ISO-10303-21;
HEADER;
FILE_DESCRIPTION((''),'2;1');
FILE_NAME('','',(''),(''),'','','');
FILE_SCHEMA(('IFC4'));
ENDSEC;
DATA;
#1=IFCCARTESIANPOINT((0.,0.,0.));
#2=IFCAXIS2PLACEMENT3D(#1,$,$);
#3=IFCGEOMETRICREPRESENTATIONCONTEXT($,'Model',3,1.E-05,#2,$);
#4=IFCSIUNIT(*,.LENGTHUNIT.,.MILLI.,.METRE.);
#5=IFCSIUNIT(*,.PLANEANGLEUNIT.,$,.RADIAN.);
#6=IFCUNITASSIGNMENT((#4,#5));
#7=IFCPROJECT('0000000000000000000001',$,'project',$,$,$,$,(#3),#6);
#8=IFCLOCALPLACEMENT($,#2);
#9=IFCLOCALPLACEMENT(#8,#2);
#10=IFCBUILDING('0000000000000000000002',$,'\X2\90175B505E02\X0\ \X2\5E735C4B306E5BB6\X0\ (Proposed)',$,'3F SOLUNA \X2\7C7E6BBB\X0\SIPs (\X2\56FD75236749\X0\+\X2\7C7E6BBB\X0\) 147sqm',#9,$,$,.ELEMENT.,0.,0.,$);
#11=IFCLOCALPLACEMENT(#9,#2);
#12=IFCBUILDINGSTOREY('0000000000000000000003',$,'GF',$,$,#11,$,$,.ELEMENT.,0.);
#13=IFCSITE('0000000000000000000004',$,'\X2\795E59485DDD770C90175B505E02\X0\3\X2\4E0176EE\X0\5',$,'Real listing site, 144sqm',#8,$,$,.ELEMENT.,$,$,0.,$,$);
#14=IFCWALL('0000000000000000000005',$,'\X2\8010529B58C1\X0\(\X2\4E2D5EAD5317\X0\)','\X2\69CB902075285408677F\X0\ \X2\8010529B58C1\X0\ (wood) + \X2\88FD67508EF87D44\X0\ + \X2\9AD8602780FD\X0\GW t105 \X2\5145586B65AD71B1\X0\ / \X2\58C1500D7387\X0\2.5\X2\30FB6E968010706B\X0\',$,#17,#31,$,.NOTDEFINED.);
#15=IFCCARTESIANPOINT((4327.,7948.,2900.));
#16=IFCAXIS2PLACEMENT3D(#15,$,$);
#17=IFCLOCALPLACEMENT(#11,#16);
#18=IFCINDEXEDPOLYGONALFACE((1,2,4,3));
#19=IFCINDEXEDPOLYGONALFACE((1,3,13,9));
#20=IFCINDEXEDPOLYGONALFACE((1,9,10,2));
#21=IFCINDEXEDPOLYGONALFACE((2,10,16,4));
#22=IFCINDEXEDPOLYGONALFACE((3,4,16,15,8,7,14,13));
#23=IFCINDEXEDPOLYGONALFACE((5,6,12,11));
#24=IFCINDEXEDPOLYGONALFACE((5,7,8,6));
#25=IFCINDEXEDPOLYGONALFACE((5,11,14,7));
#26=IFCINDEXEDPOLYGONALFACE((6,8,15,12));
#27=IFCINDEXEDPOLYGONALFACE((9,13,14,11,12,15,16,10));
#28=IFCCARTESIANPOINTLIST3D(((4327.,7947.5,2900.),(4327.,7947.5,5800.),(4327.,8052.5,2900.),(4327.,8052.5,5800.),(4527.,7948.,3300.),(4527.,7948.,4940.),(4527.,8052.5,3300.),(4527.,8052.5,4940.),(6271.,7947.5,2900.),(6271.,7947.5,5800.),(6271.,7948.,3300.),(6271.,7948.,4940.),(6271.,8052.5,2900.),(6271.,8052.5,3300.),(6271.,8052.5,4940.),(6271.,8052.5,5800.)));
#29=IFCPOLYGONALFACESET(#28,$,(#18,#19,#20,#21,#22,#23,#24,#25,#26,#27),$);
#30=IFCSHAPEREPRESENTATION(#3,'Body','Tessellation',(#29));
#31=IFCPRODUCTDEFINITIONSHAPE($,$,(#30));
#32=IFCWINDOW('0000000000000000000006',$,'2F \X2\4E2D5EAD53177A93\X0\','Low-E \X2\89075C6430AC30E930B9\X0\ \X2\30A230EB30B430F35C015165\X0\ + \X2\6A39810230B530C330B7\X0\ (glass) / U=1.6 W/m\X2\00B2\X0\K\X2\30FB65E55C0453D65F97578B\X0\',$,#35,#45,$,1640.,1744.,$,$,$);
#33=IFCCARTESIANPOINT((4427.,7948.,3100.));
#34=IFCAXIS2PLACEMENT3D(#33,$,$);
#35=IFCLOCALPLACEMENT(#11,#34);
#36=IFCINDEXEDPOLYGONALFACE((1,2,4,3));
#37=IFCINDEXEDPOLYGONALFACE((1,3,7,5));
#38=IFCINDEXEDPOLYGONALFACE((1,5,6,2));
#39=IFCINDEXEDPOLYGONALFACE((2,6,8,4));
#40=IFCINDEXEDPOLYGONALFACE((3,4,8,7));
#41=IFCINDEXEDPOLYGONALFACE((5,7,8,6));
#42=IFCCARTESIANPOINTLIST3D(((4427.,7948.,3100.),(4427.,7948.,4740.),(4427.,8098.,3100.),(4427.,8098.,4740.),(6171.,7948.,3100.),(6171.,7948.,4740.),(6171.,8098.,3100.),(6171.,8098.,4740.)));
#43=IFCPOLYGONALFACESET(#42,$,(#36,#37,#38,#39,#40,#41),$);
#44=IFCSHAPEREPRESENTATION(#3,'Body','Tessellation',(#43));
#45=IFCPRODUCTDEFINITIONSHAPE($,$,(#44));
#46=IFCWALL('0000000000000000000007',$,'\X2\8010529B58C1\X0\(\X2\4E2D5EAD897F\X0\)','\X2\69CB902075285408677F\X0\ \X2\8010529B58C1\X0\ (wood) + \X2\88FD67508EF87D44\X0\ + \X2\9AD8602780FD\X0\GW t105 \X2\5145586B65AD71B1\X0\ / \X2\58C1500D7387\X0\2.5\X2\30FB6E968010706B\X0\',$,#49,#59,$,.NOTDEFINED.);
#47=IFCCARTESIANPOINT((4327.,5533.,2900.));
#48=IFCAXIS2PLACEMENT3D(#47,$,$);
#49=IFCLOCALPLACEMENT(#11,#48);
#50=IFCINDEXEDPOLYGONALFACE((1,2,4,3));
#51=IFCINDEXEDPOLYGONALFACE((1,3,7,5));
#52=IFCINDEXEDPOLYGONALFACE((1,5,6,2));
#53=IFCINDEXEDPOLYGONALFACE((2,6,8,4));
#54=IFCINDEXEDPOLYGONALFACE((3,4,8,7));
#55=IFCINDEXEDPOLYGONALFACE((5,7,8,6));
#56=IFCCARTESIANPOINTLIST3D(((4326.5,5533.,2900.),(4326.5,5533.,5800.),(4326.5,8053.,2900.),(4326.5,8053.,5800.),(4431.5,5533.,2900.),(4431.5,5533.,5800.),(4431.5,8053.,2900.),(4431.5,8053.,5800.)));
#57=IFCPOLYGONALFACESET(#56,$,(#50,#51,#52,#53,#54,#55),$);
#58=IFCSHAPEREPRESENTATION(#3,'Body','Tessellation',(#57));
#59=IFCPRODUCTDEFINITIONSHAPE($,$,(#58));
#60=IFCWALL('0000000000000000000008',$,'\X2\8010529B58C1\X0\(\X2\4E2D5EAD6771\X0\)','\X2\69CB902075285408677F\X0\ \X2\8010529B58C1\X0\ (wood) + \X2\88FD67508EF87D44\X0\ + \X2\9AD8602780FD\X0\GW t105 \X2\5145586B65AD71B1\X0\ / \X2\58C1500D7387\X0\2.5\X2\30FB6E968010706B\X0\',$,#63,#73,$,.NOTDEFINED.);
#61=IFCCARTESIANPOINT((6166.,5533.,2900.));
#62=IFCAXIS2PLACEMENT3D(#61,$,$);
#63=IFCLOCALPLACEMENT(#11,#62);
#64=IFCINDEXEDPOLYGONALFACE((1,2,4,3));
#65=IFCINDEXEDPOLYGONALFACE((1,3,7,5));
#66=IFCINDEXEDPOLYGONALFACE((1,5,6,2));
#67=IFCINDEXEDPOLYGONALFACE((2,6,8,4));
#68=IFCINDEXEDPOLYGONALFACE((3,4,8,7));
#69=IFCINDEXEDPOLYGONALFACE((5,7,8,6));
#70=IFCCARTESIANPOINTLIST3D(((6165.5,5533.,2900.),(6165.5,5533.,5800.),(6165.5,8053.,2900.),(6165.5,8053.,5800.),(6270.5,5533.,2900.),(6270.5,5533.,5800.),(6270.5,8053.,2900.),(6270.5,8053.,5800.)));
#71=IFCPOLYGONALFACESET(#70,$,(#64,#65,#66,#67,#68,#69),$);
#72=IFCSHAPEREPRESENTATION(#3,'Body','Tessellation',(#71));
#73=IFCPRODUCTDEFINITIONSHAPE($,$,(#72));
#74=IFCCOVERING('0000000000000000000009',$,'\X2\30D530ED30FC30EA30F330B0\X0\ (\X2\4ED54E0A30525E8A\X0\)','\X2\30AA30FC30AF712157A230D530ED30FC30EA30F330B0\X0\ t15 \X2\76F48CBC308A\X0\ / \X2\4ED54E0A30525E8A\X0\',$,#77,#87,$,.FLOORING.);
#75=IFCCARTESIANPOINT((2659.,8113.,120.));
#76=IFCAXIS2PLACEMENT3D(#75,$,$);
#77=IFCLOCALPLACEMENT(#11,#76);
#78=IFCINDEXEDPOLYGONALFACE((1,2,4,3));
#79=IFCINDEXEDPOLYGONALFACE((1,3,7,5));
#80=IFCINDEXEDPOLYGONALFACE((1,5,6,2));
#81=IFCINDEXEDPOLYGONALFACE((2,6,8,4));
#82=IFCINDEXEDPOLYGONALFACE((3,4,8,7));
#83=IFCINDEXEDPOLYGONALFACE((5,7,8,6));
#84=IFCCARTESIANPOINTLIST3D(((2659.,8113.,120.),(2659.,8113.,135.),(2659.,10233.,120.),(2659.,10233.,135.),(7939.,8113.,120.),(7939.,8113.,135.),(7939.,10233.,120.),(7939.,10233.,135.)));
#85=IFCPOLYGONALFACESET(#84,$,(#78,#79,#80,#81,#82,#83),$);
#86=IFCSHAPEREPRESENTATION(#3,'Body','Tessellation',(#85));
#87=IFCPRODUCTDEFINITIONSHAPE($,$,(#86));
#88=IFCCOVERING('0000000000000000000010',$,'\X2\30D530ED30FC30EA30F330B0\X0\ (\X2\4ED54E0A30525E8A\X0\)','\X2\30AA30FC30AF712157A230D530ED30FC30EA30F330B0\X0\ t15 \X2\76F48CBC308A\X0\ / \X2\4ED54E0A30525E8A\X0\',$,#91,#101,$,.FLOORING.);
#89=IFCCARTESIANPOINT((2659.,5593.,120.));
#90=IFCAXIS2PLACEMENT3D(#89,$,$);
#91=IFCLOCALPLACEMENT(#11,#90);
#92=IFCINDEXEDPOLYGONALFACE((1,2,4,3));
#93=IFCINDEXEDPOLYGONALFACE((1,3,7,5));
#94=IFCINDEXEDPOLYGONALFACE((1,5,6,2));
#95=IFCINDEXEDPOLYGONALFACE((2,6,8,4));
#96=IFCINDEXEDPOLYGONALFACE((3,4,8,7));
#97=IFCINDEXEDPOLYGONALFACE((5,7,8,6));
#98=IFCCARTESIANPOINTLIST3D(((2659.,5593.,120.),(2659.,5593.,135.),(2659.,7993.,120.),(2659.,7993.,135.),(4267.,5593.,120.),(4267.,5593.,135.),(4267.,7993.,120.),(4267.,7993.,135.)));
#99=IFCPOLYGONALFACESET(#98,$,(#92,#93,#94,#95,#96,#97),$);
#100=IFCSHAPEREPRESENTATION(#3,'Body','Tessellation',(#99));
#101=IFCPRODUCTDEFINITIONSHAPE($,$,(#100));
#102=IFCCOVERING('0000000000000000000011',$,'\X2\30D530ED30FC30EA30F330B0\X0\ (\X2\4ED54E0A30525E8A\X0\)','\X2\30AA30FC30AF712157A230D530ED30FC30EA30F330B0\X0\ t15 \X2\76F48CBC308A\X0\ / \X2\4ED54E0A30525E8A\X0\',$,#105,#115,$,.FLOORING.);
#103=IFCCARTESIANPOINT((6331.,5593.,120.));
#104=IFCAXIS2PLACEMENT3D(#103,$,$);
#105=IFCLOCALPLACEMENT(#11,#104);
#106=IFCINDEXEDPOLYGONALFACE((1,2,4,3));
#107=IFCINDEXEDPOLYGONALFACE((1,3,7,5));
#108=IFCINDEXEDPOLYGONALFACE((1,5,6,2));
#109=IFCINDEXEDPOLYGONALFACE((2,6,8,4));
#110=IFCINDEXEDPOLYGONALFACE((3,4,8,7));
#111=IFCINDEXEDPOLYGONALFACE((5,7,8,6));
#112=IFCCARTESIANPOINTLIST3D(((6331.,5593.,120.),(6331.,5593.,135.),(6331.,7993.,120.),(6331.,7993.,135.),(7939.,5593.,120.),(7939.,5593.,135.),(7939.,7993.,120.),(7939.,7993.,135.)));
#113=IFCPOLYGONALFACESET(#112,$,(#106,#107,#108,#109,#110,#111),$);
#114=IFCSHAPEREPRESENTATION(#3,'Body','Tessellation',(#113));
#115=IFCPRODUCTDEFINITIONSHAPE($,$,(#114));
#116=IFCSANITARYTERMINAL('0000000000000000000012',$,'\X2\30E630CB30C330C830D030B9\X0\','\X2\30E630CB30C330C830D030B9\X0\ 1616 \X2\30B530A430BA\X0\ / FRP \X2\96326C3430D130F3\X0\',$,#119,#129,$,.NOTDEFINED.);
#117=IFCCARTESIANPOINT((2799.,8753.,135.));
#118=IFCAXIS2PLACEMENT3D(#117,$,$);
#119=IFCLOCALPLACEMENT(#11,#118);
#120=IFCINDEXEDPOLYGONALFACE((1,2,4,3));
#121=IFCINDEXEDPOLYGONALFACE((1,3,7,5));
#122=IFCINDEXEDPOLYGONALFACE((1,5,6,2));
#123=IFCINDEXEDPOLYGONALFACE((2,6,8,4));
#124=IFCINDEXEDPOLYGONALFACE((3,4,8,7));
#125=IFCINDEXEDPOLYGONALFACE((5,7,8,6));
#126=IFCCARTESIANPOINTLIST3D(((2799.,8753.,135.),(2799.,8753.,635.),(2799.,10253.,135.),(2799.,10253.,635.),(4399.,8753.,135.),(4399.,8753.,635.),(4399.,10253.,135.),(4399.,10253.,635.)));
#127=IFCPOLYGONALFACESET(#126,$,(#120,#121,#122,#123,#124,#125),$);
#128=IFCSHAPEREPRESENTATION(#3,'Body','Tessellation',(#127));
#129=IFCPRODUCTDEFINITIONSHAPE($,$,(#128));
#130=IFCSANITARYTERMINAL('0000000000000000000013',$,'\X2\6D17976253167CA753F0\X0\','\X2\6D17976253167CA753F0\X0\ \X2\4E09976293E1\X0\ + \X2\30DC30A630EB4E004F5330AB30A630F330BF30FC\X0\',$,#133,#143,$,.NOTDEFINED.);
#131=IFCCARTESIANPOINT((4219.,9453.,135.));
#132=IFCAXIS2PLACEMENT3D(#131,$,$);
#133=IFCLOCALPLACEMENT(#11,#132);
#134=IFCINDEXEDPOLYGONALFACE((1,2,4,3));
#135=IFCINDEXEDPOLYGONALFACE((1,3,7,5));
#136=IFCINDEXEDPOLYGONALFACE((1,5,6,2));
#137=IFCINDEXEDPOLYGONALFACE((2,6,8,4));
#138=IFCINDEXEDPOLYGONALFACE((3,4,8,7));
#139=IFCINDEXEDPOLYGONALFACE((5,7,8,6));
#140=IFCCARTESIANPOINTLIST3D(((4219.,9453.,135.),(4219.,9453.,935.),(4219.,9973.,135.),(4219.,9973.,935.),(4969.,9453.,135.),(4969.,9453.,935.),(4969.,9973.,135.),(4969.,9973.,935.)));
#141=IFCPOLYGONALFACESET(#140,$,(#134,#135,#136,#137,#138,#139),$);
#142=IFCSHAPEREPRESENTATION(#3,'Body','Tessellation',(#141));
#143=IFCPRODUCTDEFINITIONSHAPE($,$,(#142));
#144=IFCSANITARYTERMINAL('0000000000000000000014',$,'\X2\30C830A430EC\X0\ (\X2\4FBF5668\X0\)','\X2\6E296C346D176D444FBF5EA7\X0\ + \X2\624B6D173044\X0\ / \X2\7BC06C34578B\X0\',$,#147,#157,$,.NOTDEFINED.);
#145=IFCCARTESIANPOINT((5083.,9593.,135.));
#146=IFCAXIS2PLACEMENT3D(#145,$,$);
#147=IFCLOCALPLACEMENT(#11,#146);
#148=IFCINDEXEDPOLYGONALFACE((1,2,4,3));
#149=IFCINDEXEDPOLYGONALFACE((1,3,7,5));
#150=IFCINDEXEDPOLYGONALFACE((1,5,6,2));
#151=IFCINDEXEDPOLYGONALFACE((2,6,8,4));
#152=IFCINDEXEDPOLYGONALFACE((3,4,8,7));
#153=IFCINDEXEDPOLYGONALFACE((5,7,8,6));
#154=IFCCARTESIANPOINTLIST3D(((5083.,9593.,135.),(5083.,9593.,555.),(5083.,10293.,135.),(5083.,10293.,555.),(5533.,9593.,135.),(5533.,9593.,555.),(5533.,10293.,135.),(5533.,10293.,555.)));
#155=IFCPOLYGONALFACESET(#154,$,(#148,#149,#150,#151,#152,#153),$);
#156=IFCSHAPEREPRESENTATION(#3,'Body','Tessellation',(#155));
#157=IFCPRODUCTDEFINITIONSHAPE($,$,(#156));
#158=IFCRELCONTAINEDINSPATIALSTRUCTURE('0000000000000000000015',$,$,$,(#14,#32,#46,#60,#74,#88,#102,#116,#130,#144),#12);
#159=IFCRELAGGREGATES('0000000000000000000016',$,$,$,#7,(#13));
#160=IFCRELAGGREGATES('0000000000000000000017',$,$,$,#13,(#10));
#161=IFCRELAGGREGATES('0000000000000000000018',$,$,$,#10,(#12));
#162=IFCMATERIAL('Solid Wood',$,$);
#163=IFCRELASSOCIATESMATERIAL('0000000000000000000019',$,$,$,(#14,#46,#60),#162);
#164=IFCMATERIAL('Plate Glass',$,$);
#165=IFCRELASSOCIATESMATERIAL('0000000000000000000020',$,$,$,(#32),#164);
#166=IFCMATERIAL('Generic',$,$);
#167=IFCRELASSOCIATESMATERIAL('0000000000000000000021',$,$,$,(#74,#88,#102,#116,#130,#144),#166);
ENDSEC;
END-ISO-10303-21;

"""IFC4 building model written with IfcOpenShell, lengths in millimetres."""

from ifc_helpers import new_model, si_unit, frame, frame_2d, origin, place, context, project, spatial, rectangle, extrude, material, element, fill, save


model = new_model("IFC4")

# Units and contexts
model_context = context("Model", 3, precision=1e-05, world=origin())
ifc_project = project(units=[si_unit("LENGTHUNIT", "METRE", prefix="MILLI"), si_unit("PLANEANGLEUNIT", "RADIAN")], contexts=[model_context])

# Site, building, storey
site_placement = place(None, origin())
site = spatial("IfcSite", under=ifc_project, at=site_placement, Name="神奈川県逗子市3丁目5", ObjectType="Real listing site, 144sqm", CompositionType="ELEMENT", RefElevation=0.0)
building_placement = place(site_placement, origin())
building = spatial("IfcBuilding", under=site, at=building_placement, Name="逗子市 平屋の家 (Proposed)", ObjectType="3F SOLUNA 籾殻SIPs (国産杉+籾殻) 147sqm", CompositionType="ELEMENT", ElevationOfRefHeight=0.0, ElevationOfTerrain=0.0)
storey_placement = place(building_placement, origin())
storey = spatial("IfcBuildingStorey", under=building, at=storey_placement, Name="GF", CompositionType="ELEMENT", Elevation=0.0)

# Shared definitions
ifc_material_1 = material(Name="Solid Wood")

# Shared definitions
ifc_material_2 = material(Name="Plate Glass")

# Wall, opening, window
wall_1_placement = place(storey_placement, frame((4327.0, 7948.0, 2900.0)))
wall_1 = element("IfcWall", 1, at=wall_1_placement, inside=storey, material=ifc_material_1, Name="耐力壁(中庭北)", Description="構造用合板 耐力壁 (wood) + 製材軸組 + 高性能GW t105 充填断熱 / 壁倍率2.5・準耐火", PredefinedType="NOTDEFINED", context=model_context, shape_type="SweptSolid", body=[
    extrude(rectangle(XDim=1944.0, YDim=105.0, at=frame_2d((972.0, 52.0))), frame((4327.0, 7948.0, 2900.0)), (0.0, 0.0, 1.0), 2900.0),
])
opening_1_placement = place(storey_placement, frame((4427.0, 7948.0, 3100.0)))
opening_1 = element("IfcOpeningElement", 2, at=opening_1_placement, cuts=wall_1, PredefinedType="NOTDEFINED", context=model_context, shape_type="SweptSolid", body=[
    extrude(rectangle(XDim=1744.0, YDim=150.0, at=frame_2d((872.0, 75.0))), frame((4427.0, 7948.0, 3100.0)), (0.0, 0.0, 1.0), 1640.0),
])
window_1_placement = place(storey_placement, frame((4427.0, 7948.0, 3100.0)))
window_1 = element("IfcWindow", 3, at=window_1_placement, inside=storey, material=ifc_material_2, Name="2F 中庭北窓", Description="Low-E 複層ガラス アルゴン封入 + 樹脂サッシ (glass) / U=1.6 W/m²K・日射取得型", OverallHeight=1640.0, OverallWidth=1744.0, context=model_context, shape_type="SweptSolid", body=[
    extrude(rectangle(XDim=1744.0, YDim=150.0, at=frame_2d((872.0, 75.0))), frame((4427.0, 7948.0, 3100.0)), (0.0, 0.0, 1.0), 1640.0),
])
fill(opening_1, window_1)

# Walls
wall_2_placement = place(storey_placement, frame((4327.0, 5533.0, 2900.0)))
element("IfcWall", 4, at=wall_2_placement, inside=storey, material=ifc_material_1, Name="耐力壁(中庭西)", Description="構造用合板 耐力壁 (wood) + 製材軸組 + 高性能GW t105 充填断熱 / 壁倍率2.5・準耐火", PredefinedType="NOTDEFINED", context=model_context, shape_type="SweptSolid", body=[
    extrude(rectangle(XDim=105.0, YDim=2520.0, at=frame_2d((52.0, 1260.0))), frame((4327.0, 5533.0, 2900.0)), (0.0, 0.0, 1.0), 2900.0),
])
wall_3_placement = place(storey_placement, frame((6166.0, 5533.0, 2900.0)))
element("IfcWall", 5, at=wall_3_placement, inside=storey, material=ifc_material_1, Name="耐力壁(中庭東)", Description="構造用合板 耐力壁 (wood) + 製材軸組 + 高性能GW t105 充填断熱 / 壁倍率2.5・準耐火", PredefinedType="NOTDEFINED", context=model_context, shape_type="SweptSolid", body=[
    extrude(rectangle(XDim=105.0, YDim=2520.0, at=frame_2d((52.0, 1260.0))), frame((6166.0, 5533.0, 2900.0)), (0.0, 0.0, 1.0), 2900.0),
])

# Coverings
ifc_material_3 = material(Name="Generic")
covering_1_placement = place(storey_placement, frame((2659.0, 8113.0, 120.0)))
element("IfcCovering", 6, at=covering_1_placement, inside=storey, material=ifc_material_3, Name="フローリング (仕上げ床)", Description="オーク無垢フローリング t15 直貼り / 仕上げ床", PredefinedType="FLOORING", context=model_context, shape_type="SweptSolid", body=[
    extrude(rectangle(XDim=5280.0, YDim=2120.0, at=frame_2d((2640.0, 1060.0))), frame((2659.0, 8113.0, 120.0)), (0.0, 0.0, 1.0), 15.0),
])
covering_2_placement = place(storey_placement, frame((2659.0, 5593.0, 120.0)))
element("IfcCovering", 7, at=covering_2_placement, inside=storey, material=ifc_material_3, Name="フローリング (仕上げ床)", Description="オーク無垢フローリング t15 直貼り / 仕上げ床", PredefinedType="FLOORING", context=model_context, shape_type="SweptSolid", body=[
    extrude(rectangle(XDim=1608.0, YDim=2400.0, at=frame_2d((804.0, 1200.0))), frame((2659.0, 5593.0, 120.0)), (0.0, 0.0, 1.0), 15.0),
])
covering_3_placement = place(storey_placement, frame((6331.0, 5593.0, 120.0)))
element("IfcCovering", 8, at=covering_3_placement, inside=storey, material=ifc_material_3, Name="フローリング (仕上げ床)", Description="オーク無垢フローリング t15 直貼り / 仕上げ床", PredefinedType="FLOORING", context=model_context, shape_type="SweptSolid", body=[
    extrude(rectangle(XDim=1608.0, YDim=2400.0, at=frame_2d((804.0, 1200.0))), frame((6331.0, 5593.0, 120.0)), (0.0, 0.0, 1.0), 15.0),
])

# Sanitary terminals
sanitary_terminal_1_placement = place(storey_placement, frame((2799.0, 8753.0, 135.0)))
element("IfcSanitaryTerminal", 9, at=sanitary_terminal_1_placement, inside=storey, material=ifc_material_3, Name="ユニットバス", Description="ユニットバス 1616 サイズ / FRP 防水パン", PredefinedType="NOTDEFINED", context=model_context, shape_type="SweptSolid", body=[
    extrude(rectangle(XDim=1600.0, YDim=1500.0, at=frame_2d((800.0, 750.0))), frame((2799.0, 8753.0, 135.0)), (0.0, 0.0, 1.0), 500.0),
])
sanitary_terminal_2_placement = place(storey_placement, frame((4219.0, 9453.0, 135.0)))
element("IfcSanitaryTerminal", 10, at=sanitary_terminal_2_placement, inside=storey, material=ifc_material_3, Name="洗面化粧台", Description="洗面化粧台 三面鏡 + ボウル一体カウンター", PredefinedType="NOTDEFINED", context=model_context, shape_type="SweptSolid", body=[
    extrude(rectangle(XDim=750.0, YDim=520.0, at=frame_2d((375.0, 260.0))), frame((4219.0, 9453.0, 135.0)), (0.0, 0.0, 1.0), 800.0),
])
sanitary_terminal_3_placement = place(storey_placement, frame((5083.0, 9593.0, 135.0)))
element("IfcSanitaryTerminal", 11, at=sanitary_terminal_3_placement, inside=storey, material=ifc_material_3, Name="トイレ (便器)", Description="温水洗浄便座 + 手洗い / 節水型", PredefinedType="NOTDEFINED", context=model_context, shape_type="SweptSolid", body=[
    extrude(rectangle(XDim=450.0, YDim=700.0, at=frame_2d((225.0, 350.0))), frame((5083.0, 9593.0, 135.0)), (0.0, 0.0, 1.0), 420.0),
])

save(model, "model.ifc")
